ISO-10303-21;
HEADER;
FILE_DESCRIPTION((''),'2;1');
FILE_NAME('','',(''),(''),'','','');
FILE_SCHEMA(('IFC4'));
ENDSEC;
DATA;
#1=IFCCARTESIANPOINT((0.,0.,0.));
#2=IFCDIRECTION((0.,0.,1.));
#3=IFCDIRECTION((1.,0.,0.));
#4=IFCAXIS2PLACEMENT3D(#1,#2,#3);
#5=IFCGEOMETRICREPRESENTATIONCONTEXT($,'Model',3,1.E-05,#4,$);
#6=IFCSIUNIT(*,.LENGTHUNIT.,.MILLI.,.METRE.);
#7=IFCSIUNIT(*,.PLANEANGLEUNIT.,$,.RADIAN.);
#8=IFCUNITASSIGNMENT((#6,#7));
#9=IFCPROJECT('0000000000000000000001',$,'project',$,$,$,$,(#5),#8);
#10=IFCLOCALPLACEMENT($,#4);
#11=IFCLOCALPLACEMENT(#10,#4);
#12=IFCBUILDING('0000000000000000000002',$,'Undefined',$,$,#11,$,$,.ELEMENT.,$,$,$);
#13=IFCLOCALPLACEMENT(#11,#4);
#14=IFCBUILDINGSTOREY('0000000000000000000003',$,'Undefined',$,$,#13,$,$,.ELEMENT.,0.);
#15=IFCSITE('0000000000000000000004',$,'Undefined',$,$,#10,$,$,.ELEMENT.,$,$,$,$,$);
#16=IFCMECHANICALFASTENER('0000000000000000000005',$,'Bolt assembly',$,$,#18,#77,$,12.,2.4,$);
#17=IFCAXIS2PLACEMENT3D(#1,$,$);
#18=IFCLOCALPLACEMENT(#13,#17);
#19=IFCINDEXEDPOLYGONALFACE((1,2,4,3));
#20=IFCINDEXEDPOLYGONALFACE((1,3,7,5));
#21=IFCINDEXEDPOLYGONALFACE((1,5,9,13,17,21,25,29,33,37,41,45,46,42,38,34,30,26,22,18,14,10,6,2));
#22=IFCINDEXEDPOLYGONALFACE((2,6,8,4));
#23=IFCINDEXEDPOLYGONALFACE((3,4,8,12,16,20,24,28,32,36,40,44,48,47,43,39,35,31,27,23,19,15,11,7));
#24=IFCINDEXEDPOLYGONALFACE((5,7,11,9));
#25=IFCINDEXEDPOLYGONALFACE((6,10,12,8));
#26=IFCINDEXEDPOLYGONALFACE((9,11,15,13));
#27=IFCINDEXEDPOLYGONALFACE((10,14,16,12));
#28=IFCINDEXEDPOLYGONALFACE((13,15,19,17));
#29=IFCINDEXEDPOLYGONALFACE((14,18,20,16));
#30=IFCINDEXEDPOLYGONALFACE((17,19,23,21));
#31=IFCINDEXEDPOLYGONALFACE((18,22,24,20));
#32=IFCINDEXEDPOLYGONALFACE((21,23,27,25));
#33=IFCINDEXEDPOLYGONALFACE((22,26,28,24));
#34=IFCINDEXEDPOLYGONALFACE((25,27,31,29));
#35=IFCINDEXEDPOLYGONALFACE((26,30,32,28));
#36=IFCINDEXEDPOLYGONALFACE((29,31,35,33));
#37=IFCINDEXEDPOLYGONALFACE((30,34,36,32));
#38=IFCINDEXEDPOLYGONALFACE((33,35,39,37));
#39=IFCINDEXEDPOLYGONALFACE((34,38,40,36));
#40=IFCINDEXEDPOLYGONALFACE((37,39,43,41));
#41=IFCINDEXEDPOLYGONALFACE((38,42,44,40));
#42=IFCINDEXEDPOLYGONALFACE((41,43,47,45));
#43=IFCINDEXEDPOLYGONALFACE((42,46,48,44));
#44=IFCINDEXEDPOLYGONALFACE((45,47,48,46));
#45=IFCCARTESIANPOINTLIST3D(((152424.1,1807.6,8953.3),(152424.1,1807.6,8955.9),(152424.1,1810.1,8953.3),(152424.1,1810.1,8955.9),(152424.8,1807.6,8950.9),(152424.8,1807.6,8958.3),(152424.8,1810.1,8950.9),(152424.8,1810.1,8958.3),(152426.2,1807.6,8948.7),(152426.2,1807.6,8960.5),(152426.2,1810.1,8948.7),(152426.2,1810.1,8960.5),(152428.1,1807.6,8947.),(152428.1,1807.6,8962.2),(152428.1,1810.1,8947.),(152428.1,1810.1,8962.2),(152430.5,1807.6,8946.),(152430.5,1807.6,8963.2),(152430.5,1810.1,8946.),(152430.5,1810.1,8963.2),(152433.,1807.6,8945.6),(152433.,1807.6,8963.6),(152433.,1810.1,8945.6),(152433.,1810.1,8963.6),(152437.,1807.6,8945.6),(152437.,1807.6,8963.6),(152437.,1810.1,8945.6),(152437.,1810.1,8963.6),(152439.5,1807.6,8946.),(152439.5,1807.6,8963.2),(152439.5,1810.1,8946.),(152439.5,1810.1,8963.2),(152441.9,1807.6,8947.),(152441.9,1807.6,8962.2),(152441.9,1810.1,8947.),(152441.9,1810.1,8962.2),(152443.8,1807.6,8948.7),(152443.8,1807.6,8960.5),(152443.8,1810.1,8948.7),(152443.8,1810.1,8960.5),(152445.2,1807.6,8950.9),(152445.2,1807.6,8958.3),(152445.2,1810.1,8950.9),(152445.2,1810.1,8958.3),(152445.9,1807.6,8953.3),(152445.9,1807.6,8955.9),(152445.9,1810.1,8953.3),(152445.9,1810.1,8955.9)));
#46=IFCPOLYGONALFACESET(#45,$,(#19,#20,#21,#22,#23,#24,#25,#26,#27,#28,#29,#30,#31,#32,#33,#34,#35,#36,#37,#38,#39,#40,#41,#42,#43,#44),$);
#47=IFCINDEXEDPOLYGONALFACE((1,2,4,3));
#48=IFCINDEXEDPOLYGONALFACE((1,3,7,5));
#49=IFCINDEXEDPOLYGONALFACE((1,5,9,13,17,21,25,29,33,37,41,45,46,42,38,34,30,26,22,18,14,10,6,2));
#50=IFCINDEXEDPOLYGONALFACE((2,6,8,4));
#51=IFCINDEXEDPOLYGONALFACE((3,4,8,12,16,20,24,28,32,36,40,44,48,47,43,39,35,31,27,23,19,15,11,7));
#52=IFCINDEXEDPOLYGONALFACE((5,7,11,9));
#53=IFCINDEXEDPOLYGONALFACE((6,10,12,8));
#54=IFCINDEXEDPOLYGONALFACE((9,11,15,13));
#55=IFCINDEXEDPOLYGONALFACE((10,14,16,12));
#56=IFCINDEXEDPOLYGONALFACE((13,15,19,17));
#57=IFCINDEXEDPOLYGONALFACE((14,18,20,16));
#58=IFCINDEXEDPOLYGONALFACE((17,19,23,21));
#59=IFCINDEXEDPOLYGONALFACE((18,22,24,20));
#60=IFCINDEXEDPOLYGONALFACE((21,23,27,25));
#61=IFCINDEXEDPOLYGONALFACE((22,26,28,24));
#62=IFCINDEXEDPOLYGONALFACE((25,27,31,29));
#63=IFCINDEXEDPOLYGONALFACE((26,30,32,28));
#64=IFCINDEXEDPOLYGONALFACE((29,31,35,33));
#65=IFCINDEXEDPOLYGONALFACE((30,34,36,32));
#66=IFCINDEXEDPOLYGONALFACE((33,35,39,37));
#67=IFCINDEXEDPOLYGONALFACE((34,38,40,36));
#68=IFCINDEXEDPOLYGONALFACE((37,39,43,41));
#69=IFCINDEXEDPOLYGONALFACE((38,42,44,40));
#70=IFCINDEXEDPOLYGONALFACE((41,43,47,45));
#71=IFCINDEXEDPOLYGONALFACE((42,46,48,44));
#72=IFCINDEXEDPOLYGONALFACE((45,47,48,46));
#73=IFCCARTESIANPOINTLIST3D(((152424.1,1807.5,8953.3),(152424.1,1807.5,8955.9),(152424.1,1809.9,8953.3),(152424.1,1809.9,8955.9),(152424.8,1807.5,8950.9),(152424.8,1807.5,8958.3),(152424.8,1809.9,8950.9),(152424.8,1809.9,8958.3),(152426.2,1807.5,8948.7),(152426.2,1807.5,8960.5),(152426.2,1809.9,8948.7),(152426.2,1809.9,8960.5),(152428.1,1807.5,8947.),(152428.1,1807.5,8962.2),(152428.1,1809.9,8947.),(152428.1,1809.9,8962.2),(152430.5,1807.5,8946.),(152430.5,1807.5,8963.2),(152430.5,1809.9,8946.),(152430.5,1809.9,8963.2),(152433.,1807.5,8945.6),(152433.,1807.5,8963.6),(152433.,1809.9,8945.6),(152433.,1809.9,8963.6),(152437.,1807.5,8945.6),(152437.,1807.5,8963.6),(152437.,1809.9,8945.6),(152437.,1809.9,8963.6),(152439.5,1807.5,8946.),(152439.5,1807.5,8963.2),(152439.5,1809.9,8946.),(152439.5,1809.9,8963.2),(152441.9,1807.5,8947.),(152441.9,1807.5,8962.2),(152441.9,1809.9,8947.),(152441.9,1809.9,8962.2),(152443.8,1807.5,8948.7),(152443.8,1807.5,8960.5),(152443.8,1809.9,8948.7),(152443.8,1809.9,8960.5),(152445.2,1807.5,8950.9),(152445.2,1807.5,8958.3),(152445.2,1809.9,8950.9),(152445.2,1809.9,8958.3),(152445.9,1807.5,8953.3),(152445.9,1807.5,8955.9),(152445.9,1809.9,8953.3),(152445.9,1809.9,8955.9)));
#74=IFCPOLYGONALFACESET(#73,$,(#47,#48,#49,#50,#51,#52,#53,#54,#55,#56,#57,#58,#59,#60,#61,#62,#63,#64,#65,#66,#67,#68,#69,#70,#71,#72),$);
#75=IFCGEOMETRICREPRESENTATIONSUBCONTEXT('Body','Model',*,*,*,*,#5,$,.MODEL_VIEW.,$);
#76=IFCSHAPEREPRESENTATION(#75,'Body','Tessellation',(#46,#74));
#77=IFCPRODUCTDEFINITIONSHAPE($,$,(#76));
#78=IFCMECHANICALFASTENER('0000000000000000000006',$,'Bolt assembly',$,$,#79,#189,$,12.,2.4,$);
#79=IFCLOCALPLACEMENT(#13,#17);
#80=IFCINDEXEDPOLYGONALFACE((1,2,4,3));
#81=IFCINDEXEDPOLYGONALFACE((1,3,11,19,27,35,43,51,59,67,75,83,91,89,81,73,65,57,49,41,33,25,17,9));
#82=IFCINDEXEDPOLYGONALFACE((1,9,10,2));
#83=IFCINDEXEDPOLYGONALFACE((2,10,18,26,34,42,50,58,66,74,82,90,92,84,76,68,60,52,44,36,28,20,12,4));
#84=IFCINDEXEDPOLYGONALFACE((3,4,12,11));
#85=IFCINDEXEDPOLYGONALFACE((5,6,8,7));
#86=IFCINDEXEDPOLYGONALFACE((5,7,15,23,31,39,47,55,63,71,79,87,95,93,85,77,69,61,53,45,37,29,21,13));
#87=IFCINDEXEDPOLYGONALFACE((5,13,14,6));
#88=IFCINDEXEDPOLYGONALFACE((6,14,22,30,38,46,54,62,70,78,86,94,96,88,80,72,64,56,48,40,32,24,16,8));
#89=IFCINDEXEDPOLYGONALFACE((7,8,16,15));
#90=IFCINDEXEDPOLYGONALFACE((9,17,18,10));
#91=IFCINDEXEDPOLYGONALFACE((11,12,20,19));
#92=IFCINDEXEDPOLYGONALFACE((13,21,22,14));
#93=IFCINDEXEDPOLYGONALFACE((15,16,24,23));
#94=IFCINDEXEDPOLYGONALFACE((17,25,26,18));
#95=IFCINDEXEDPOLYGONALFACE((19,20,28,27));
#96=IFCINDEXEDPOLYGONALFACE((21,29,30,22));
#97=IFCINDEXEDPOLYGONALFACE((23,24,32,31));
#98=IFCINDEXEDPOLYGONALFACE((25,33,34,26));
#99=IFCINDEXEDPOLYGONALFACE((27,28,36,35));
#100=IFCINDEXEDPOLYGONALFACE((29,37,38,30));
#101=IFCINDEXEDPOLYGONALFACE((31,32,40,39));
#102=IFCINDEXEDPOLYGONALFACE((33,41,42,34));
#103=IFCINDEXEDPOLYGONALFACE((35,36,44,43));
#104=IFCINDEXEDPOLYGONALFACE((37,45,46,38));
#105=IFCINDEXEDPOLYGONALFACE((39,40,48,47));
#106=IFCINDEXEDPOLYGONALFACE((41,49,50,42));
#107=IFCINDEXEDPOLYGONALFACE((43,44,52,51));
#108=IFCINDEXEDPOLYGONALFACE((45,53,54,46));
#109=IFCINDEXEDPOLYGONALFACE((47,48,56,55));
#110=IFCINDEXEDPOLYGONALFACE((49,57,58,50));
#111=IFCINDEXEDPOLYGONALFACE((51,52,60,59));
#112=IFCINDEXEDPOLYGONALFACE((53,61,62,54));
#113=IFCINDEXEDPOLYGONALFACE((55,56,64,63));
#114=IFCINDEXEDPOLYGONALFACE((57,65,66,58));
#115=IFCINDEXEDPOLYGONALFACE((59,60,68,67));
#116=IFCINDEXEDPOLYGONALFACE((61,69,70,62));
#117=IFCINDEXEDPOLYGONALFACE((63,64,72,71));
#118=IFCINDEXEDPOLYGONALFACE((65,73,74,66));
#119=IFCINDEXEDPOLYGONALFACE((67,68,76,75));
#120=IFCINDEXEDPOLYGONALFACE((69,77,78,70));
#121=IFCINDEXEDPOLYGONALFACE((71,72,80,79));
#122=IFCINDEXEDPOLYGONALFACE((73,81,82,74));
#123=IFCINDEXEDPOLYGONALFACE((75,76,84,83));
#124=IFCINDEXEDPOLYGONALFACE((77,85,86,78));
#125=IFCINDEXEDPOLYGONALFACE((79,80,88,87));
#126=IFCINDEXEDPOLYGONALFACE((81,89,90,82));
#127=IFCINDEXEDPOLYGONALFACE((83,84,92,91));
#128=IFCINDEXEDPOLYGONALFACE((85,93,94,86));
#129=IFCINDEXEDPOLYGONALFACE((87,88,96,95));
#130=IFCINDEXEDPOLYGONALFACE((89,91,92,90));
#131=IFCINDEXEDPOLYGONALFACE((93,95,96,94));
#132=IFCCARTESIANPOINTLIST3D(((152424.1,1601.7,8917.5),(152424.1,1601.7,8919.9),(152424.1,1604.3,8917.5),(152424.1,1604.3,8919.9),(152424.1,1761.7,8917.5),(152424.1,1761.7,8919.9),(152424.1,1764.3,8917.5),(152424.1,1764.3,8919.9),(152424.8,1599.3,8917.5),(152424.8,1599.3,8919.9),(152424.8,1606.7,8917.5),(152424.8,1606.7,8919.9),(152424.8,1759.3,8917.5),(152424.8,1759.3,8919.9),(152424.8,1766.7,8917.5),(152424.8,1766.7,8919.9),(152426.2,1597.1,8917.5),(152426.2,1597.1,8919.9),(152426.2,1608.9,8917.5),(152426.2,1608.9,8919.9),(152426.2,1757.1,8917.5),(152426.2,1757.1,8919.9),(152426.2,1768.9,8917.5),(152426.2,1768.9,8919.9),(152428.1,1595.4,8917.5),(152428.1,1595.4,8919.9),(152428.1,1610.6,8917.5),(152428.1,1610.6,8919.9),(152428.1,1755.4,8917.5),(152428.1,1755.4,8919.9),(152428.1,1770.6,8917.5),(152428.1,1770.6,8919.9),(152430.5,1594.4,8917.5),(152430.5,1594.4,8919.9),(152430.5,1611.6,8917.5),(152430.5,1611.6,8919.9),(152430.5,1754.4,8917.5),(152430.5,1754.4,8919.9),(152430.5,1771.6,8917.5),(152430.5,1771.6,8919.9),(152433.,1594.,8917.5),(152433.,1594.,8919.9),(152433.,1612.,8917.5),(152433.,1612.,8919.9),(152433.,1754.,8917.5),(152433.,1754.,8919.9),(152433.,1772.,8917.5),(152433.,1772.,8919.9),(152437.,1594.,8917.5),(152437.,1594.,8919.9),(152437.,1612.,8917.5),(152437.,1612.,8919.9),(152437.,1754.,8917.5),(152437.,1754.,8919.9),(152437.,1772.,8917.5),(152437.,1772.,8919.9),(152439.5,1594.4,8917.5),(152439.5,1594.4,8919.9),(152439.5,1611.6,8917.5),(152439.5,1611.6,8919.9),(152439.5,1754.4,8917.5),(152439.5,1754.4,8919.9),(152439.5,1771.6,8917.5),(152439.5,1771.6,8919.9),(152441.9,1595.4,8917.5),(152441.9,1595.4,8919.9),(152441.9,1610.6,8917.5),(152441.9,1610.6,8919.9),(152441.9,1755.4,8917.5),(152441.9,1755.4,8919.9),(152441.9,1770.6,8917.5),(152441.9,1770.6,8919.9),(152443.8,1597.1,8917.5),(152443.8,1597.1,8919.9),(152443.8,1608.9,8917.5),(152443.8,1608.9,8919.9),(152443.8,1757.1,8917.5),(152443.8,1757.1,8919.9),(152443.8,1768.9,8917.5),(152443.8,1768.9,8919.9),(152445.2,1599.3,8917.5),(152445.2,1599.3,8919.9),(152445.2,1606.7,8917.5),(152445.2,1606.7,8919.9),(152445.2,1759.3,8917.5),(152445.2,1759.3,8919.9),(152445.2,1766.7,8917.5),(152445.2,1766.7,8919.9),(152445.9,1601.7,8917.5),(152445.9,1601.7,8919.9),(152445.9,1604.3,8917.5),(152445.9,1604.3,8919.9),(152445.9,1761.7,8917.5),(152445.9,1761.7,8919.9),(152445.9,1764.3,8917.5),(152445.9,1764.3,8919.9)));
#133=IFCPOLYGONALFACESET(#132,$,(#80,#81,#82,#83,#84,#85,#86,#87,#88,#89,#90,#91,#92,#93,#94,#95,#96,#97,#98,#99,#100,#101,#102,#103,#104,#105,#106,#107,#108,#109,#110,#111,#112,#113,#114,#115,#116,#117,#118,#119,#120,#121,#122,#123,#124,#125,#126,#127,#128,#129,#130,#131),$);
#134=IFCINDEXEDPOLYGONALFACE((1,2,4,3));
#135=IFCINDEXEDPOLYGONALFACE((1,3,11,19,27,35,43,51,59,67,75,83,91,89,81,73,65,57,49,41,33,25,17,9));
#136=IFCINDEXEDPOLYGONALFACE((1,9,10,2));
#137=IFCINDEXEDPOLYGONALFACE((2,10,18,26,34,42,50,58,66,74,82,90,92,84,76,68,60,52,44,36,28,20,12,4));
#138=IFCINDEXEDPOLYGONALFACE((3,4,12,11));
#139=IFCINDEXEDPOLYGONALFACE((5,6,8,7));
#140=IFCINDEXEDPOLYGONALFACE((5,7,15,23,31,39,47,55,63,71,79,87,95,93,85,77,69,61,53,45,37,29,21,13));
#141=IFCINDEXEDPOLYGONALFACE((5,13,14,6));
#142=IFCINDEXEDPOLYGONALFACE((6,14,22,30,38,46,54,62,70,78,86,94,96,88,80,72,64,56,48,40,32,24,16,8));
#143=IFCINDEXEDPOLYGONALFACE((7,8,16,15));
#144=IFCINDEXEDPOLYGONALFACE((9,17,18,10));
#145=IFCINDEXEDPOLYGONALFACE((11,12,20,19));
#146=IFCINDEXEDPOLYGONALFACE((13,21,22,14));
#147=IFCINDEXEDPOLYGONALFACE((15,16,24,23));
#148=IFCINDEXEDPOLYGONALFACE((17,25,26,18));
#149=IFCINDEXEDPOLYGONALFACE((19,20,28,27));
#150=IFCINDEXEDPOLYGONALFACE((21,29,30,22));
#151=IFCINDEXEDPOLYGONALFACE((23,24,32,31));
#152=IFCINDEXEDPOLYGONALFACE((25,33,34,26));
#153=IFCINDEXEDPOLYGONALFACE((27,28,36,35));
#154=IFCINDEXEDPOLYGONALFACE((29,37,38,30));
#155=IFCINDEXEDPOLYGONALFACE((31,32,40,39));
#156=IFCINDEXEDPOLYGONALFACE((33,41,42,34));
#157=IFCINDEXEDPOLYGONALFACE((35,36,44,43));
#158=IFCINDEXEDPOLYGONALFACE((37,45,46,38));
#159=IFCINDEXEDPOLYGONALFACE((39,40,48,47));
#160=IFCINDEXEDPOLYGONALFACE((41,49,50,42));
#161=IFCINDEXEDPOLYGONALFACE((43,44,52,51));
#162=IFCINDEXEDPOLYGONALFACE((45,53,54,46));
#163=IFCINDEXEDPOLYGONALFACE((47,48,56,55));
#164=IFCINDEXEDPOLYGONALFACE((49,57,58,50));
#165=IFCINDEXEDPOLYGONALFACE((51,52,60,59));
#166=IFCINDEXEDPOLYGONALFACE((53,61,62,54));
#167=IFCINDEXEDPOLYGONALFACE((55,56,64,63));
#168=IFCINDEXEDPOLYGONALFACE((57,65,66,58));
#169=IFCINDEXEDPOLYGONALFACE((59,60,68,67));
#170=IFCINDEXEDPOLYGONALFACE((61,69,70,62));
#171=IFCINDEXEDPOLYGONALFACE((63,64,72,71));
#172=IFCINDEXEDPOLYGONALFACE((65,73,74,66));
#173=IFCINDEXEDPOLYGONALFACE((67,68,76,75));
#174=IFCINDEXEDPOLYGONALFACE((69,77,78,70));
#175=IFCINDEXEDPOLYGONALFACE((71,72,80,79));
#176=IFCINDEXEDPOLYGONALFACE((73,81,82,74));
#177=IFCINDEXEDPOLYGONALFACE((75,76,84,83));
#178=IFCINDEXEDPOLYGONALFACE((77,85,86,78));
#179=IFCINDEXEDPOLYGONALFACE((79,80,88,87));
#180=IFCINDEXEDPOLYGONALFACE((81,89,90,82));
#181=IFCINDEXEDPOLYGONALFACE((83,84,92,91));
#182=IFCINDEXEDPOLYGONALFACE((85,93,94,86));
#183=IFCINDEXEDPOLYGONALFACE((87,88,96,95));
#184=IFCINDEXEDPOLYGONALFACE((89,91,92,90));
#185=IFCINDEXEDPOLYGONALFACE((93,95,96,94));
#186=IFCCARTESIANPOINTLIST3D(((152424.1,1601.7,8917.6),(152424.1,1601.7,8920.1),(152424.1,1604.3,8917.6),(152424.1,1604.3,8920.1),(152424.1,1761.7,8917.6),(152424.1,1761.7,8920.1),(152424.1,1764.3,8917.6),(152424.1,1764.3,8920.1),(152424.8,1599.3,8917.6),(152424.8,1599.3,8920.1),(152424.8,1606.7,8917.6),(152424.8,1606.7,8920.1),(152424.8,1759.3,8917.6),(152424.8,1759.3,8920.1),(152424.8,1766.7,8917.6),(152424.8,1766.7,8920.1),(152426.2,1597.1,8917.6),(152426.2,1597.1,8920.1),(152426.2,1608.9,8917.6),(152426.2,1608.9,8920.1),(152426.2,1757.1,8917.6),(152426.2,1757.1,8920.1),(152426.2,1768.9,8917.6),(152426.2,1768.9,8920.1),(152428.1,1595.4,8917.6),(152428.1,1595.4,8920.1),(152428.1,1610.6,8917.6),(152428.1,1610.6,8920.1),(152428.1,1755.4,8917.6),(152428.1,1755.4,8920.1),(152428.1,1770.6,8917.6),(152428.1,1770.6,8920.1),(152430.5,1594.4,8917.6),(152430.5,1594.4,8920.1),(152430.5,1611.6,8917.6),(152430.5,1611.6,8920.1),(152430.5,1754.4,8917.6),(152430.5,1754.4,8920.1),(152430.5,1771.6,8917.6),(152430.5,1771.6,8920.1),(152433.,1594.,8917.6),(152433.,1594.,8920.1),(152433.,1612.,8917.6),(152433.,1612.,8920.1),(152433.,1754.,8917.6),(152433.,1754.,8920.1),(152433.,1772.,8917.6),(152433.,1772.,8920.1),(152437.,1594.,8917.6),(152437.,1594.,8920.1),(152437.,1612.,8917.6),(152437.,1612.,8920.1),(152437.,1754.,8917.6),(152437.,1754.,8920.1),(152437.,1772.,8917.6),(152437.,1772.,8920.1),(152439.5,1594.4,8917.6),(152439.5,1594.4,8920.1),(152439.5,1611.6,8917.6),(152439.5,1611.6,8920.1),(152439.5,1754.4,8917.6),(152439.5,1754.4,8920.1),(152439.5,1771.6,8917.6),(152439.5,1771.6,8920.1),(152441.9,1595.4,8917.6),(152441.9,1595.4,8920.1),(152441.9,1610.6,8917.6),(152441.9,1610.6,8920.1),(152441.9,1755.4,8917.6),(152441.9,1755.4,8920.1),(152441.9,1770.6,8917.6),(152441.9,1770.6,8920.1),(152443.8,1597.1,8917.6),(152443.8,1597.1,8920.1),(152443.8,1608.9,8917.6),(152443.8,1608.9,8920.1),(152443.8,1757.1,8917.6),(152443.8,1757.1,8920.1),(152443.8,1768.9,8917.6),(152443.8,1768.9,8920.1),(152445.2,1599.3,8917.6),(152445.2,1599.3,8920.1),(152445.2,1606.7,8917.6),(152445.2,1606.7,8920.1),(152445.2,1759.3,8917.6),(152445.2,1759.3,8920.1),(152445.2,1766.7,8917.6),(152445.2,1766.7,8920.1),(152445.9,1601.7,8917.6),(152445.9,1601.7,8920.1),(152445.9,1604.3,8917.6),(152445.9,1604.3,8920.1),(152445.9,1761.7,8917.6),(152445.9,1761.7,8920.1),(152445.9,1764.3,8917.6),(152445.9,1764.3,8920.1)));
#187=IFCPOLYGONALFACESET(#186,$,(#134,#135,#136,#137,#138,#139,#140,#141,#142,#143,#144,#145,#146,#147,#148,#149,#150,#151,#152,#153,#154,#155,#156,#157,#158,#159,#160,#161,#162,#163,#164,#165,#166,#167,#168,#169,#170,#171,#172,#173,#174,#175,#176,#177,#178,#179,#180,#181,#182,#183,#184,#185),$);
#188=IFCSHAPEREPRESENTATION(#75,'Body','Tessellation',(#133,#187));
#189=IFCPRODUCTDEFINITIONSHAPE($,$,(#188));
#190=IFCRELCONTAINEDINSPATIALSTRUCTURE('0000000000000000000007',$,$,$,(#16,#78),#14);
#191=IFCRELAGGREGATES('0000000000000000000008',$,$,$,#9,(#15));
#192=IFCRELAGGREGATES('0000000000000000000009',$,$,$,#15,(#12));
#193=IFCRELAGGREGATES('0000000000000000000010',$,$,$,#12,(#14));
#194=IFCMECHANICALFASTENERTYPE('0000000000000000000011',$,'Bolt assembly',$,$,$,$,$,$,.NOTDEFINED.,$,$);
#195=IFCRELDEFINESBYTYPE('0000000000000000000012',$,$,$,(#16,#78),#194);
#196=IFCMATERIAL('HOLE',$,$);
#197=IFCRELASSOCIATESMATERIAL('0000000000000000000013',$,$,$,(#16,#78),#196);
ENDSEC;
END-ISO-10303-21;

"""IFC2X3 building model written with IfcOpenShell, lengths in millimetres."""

from ifc_helpers import new_model, entity, si_unit, frame, origin_with_axes, place, context, subcontext, project, spatial, source, transform, mapped, material, type_object, element, save


model = new_model("IFC2X3")

# Units and contexts
model_context = context("Model", 3, precision=1e-05, world=origin_with_axes())
body_context = subcontext(model_context, "Body", "Model", "MODEL_VIEW")
ifc_project = project(units=[si_unit("LENGTHUNIT", "METRE", prefix="MILLI"), si_unit("PLANEANGLEUNIT", "RADIAN")], contexts=[model_context])

# Site, building, storey
site_placement = place(None, origin_with_axes())
site = spatial("IfcSite", under=ifc_project, at=site_placement, Name="Undefined", CompositionType="ELEMENT")
building_placement = place(site_placement, origin_with_axes())
building = spatial("IfcBuilding", under=site, at=building_placement, Name="Undefined", CompositionType="ELEMENT")
storey_placement = place(building_placement, origin_with_axes())
storey = spatial("IfcBuildingStorey", under=building, at=storey_placement, Name="Undefined", CompositionType="ELEMENT", Elevation=0.0)

# Mechanical fasteners
ifc_material_1 = material(Name="HOLE")
mechanical_fastener_type = type_object("IfcMechanicalFastenerType", Name="Bolt assembly")
shared_circle_1 = entity("IfcCircle", entity("IfcAxis2Placement2D", entity("IfcCartesianPoint", [2.0, 0.0]), entity("IfcDirection", [0.0, 1.0])), 9.0)
shared_circle_2 = entity("IfcCircle", entity("IfcAxis2Placement2D", entity("IfcCartesianPoint", [-2.0, 0.0]), entity("IfcDirection", [0.0, -1.0])), 9.0)
shared_composite_curve = entity("IfcCompositeCurve", [entity("IfcCompositeCurveSegment", "CONTINUOUS", True, entity("IfcPolyline", [entity("IfcCartesianPoint", [-2.0, 9.0]), entity("IfcCartesianPoint", [2.0, 9.0])])), entity("IfcCompositeCurveSegment", "CONTINUOUS", True, entity("IfcTrimmedCurve", shared_circle_1, [entity("IfcParameterValue", 0.0)], [entity("IfcParameterValue", 3.141593)], False, "PARAMETER")), entity("IfcCompositeCurveSegment", "CONTINUOUS", True, entity("IfcPolyline", [entity("IfcCartesianPoint", [2.0, -9.0]), entity("IfcCartesianPoint", [-2.0, -9.0])])), entity("IfcCompositeCurveSegment", "DISCONTINUOUS", True, entity("IfcTrimmedCurve", shared_circle_2, [entity("IfcParameterValue", 0.0)], [entity("IfcParameterValue", 3.141593)], False, "PARAMETER"))], False)
shared_shape_1 = source(origin_with_axes(), body_context, "Body", "SweptSolid", [
    entity("IfcExtrudedAreaSolid", entity("IfcArbitraryClosedProfileDef", "AREA", None, shared_composite_curve), entity("IfcAxis2Placement3D", entity("IfcCartesianPoint", [0.0, -2.5, 0.0]), entity("IfcDirection", [0.0, 1.0, 0.0]), entity("IfcDirection", [1.0, 0.0, 0.0])), entity("IfcDirection", [0.0, 0.0, 1.0]), 2.5),
    entity("IfcExtrudedAreaSolid", entity("IfcArbitraryClosedProfileDef", "AREA", None, shared_composite_curve), entity("IfcAxis2Placement3D", entity("IfcCartesianPoint", [0.0, -2.3, 0.0]), entity("IfcDirection", [0.0, 1.0, 0.0]), entity("IfcDirection", [1.0, 0.0, 0.0])), entity("IfcDirection", [0.0, 0.0, 1.0]), 2.4),
])
mechanical_fastener_1_placement = place(storey_placement, frame((152435.0, 1807.6, 8954.6), z_axis=(0.0, 0.0, -1.0), x_axis=(1.0, 0.0, 0.0)))
element("IfcMechanicalFastener", 1, at=mechanical_fastener_1_placement, inside=storey, type_object=mechanical_fastener_type, material=ifc_material_1, Name="Bolt assembly", NominalDiameter=12.0, NominalLength=2.4, context=body_context, shape_type="MappedRepresentation", body=[
    mapped(shared_shape_1, transform((0.0, 0.0, 0.0))),
])
shared_shape_2 = source(origin_with_axes(), body_context, "Body", "SweptSolid", [
    entity("IfcExtrudedAreaSolid", entity("IfcArbitraryClosedProfileDef", "AREA", None, shared_composite_curve), entity("IfcAxis2Placement3D", entity("IfcCartesianPoint", [0.0, -2.3, 0.0]), entity("IfcDirection", [0.0, 1.0, 0.0]), entity("IfcDirection", [1.0, 0.0, 0.0])), entity("IfcDirection", [0.0, 0.0, 1.0]), 2.4),
    entity("IfcExtrudedAreaSolid", entity("IfcArbitraryClosedProfileDef", "AREA", None, shared_composite_curve), entity("IfcAxis2Placement3D", entity("IfcCartesianPoint", [0.0, -2.5, 0.0]), entity("IfcDirection", [0.0, 1.0, 0.0]), entity("IfcDirection", [1.0, 0.0, 0.0])), entity("IfcDirection", [0.0, 0.0, 1.0]), 2.5),
])
mechanical_fastener_2_placement = place(storey_placement, frame((152435.0, 1683.0, 8917.6), z_axis=(0.0, 1.0, 0.0), x_axis=(1.0, 0.0, 0.0)))
element("IfcMechanicalFastener", 2, at=mechanical_fastener_2_placement, inside=storey, type_object=mechanical_fastener_type, material=ifc_material_1, Name="Bolt assembly", NominalDiameter=12.0, NominalLength=2.4, context=body_context, shape_type="MappedRepresentation", body=[
    mapped(shared_shape_2, transform((0.0, 0.0, -80.0))),
    mapped(shared_shape_2, transform((0.0, 0.0, 80.0))),
])

save(model, "model.ifc")
